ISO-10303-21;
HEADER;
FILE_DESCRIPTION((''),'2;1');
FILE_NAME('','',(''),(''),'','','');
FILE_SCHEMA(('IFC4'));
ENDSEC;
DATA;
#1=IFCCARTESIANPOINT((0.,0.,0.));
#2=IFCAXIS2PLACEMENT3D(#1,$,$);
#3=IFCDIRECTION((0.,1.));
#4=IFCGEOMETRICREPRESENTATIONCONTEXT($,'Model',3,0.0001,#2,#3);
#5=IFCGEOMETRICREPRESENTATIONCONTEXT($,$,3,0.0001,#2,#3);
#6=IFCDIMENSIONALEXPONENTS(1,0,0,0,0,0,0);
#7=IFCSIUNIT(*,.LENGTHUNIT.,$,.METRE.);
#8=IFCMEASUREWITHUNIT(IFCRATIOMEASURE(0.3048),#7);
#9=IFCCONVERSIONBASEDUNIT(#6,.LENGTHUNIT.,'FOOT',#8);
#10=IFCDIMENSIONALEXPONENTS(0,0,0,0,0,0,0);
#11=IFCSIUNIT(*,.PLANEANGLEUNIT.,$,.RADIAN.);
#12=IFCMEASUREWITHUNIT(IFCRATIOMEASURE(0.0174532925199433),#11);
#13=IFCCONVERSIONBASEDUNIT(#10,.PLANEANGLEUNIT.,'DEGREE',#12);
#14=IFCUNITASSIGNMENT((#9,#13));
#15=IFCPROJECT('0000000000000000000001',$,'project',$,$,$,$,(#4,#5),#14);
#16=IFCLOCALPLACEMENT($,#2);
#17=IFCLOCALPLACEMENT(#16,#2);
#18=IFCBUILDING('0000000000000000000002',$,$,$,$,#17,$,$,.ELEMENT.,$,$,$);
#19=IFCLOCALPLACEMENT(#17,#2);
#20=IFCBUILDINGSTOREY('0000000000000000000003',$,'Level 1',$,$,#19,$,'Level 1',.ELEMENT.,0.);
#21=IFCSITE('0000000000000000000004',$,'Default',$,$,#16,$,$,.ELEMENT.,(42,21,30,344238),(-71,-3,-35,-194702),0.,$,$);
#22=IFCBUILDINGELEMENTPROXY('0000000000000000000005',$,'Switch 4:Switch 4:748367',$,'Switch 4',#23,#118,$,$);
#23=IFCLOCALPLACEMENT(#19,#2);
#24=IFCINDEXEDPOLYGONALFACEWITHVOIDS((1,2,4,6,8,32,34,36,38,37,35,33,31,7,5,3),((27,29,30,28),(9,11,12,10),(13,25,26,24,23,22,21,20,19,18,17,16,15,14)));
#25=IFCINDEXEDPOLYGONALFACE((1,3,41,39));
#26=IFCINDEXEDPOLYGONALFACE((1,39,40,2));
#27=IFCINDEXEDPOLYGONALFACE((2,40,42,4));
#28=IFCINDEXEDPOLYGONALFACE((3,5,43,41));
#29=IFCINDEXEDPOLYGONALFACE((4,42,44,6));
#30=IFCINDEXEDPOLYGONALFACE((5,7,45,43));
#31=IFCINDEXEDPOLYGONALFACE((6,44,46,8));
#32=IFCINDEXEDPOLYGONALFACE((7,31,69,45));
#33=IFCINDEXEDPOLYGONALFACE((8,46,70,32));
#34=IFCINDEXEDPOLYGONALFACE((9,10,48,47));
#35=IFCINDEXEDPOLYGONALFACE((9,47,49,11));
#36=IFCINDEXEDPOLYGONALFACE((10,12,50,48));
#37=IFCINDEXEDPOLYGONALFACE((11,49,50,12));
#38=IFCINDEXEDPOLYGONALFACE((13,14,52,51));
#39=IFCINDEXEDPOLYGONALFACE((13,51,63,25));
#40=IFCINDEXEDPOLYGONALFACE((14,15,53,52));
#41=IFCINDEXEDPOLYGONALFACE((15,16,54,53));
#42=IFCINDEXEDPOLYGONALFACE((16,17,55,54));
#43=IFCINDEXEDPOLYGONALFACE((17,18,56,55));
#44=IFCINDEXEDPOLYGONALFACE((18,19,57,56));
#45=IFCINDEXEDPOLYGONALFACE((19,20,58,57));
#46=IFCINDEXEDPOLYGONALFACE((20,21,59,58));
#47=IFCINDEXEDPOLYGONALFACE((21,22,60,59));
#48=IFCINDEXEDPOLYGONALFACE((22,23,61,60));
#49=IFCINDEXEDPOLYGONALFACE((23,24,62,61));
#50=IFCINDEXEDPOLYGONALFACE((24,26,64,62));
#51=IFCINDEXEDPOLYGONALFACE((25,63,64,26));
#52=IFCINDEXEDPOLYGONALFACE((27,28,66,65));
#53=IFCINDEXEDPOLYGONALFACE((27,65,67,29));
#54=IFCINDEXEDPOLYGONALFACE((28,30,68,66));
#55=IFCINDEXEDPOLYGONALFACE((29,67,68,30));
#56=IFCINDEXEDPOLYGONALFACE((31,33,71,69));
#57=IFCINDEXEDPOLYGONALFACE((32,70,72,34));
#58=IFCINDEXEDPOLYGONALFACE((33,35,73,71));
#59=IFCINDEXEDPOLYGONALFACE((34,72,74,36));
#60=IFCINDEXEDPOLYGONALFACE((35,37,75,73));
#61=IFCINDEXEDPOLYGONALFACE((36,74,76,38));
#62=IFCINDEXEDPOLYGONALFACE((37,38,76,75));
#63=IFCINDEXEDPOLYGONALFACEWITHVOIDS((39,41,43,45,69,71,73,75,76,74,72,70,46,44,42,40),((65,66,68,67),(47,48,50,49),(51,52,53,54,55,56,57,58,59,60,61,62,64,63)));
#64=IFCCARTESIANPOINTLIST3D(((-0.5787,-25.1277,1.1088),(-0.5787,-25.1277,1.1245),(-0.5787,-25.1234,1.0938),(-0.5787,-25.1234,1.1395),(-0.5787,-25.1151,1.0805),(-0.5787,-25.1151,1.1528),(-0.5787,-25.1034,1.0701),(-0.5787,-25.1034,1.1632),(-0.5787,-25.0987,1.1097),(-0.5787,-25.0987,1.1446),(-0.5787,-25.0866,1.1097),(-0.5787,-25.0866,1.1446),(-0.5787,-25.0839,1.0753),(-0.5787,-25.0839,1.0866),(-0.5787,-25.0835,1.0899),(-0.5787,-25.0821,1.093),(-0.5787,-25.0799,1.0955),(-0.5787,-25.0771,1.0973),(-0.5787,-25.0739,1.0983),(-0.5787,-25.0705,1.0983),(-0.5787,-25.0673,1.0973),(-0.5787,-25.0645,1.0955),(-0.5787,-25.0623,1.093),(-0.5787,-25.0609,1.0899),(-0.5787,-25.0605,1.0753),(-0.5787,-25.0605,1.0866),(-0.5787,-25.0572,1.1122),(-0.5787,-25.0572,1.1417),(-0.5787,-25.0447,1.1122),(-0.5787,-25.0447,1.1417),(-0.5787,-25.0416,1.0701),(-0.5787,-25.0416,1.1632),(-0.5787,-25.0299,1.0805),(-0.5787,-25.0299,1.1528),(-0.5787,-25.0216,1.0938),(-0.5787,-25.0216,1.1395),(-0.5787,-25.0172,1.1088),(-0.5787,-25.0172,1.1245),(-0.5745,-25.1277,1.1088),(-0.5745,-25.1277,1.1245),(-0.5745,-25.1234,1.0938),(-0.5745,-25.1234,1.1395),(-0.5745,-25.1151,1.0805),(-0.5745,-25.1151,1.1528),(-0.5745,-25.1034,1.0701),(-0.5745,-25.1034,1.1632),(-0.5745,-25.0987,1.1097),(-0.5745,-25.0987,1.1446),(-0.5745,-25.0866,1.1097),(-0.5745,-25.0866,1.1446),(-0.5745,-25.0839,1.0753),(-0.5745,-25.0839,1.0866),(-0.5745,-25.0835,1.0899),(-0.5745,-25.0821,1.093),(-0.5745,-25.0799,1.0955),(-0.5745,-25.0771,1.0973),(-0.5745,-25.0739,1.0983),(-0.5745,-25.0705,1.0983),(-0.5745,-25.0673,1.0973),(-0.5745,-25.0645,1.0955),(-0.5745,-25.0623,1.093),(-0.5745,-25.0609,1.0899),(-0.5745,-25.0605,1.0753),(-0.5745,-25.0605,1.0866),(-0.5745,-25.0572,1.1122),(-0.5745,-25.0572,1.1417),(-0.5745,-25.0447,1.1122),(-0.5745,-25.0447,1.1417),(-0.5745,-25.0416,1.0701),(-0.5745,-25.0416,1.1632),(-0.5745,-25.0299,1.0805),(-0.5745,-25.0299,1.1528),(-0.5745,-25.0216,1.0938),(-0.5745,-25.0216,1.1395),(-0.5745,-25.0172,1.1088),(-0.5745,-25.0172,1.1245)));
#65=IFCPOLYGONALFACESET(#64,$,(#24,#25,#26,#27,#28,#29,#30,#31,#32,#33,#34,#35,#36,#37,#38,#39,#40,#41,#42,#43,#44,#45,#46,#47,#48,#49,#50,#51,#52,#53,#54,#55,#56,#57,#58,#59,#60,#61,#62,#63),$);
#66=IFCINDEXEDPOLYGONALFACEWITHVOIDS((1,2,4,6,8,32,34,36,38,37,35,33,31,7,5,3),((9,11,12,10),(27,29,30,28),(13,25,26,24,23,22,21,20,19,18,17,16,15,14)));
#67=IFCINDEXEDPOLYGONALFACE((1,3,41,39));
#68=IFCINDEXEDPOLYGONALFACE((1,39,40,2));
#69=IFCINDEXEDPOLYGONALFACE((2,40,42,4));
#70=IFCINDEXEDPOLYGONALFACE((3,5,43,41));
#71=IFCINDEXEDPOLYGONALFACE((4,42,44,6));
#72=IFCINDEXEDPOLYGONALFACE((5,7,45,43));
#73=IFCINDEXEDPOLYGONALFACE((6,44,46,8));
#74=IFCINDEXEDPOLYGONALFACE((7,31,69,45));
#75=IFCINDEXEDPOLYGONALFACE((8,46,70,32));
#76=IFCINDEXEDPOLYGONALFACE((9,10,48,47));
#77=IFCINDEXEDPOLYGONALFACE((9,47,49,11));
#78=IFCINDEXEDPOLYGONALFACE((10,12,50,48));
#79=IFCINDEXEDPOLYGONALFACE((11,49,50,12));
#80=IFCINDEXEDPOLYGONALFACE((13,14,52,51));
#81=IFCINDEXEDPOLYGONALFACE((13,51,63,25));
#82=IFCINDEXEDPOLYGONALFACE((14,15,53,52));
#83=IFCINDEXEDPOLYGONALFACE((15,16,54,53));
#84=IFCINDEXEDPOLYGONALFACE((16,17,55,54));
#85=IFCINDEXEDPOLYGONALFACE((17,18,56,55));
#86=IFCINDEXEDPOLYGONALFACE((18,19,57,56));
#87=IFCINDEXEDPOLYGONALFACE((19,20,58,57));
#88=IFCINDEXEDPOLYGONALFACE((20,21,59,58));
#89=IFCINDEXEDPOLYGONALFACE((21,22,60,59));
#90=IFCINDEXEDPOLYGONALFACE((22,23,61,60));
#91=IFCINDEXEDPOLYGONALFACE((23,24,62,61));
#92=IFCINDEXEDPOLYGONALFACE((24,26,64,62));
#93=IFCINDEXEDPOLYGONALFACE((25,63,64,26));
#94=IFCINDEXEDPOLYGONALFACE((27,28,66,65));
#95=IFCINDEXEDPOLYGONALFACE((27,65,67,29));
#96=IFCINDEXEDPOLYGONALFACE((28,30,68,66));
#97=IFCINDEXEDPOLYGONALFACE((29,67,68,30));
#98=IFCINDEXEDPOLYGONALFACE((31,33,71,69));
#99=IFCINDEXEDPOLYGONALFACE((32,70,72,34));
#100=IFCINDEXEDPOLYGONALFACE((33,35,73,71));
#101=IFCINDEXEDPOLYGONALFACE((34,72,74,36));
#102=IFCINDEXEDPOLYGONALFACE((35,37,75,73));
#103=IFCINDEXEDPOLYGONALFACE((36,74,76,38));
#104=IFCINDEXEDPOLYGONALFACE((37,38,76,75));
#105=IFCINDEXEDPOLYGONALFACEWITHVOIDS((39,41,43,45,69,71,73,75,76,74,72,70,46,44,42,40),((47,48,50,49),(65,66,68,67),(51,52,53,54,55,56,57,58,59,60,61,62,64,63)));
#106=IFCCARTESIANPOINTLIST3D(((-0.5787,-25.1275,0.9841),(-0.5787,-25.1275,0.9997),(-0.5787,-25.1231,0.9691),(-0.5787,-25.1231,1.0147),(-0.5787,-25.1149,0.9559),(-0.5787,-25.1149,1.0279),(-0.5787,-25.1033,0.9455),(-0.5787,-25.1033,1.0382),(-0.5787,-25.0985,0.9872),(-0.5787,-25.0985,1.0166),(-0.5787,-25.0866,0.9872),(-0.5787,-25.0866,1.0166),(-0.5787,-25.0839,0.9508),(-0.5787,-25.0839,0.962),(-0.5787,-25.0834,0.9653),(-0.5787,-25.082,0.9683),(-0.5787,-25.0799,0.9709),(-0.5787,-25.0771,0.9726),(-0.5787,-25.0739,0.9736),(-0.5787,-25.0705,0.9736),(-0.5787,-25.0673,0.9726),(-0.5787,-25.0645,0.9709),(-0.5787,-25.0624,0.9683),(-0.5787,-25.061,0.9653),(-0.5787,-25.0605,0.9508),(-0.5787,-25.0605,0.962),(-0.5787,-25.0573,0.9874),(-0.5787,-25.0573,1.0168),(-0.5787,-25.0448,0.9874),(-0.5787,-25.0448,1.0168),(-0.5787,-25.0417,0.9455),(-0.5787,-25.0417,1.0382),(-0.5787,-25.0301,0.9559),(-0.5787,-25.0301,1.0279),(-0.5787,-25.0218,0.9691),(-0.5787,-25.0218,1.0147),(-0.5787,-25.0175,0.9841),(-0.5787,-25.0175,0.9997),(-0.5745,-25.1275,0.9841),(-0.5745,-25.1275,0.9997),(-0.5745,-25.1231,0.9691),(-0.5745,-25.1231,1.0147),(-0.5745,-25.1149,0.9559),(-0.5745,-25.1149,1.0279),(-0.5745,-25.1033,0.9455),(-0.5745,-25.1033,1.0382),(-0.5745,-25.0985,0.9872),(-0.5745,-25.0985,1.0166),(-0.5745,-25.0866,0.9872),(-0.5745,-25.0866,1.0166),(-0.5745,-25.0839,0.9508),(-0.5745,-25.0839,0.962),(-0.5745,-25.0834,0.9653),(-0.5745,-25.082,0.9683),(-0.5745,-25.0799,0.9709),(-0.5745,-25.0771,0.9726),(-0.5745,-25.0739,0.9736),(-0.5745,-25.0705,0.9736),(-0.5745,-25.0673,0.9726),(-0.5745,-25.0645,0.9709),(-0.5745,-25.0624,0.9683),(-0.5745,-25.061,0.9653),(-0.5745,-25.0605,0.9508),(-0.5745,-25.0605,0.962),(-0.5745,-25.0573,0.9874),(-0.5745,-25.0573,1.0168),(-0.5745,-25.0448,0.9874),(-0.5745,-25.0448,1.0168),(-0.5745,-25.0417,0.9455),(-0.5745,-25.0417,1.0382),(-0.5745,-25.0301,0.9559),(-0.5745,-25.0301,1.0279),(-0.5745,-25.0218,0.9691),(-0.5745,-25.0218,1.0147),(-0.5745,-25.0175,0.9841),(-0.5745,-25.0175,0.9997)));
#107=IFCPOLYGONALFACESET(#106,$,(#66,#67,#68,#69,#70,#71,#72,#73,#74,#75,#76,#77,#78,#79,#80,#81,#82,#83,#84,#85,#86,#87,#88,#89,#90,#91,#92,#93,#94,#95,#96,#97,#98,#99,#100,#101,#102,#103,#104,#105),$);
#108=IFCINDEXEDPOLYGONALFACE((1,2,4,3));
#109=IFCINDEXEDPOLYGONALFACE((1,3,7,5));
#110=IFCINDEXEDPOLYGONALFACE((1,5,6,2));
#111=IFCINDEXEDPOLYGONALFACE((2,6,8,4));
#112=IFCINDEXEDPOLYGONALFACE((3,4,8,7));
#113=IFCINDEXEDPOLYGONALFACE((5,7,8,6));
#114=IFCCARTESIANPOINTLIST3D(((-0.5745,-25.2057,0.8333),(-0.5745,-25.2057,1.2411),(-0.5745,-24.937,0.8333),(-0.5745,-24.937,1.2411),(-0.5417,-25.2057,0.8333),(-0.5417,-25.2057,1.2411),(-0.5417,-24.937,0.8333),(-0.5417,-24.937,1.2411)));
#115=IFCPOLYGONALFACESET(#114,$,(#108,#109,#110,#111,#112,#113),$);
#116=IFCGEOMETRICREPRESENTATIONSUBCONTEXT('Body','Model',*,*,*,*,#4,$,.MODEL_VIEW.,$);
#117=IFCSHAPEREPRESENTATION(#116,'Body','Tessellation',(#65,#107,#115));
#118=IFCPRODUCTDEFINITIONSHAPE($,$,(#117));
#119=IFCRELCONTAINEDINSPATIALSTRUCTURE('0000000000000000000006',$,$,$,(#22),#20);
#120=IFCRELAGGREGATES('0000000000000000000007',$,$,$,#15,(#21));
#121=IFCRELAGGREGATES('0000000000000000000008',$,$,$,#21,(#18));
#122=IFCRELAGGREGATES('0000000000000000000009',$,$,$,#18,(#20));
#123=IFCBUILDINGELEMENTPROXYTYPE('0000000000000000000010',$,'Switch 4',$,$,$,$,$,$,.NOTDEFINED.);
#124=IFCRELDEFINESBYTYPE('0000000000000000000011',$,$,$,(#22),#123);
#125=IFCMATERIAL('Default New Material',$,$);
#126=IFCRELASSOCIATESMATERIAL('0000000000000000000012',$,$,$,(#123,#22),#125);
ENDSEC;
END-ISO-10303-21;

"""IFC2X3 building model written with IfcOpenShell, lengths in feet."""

from ifc_helpers import new_model, entity, si_unit, converted_unit, direction, frame, frame_2d, origin, origin_2d_with_axis, place, context, subcontext, project, spatial, polyline, circle_curve, parameter, trimmed, segment, composite_curve, rectangle, outline, extrude, source, transform, mapped, material, type_object, type_shapes, element, save


model = new_model("IFC2X3")

# Units and contexts
model_context = context("Model", 3, precision=0.0001, world=origin(), true_north=direction((0.0, 1.0)))
context_of_model = context(None, 3, precision=0.0001, world=origin(), true_north=direction((0.0, 1.0)))
body_context = subcontext(model_context, "Body", "Model", "MODEL_VIEW")
ifc_project = project(units=[converted_unit("LENGTHUNIT", "FOOT", entity("IfcRatioMeasure", 0.3048), si_unit("LENGTHUNIT", "METRE"), dimensions=[1, 0, 0, 0, 0, 0, 0]), converted_unit("PLANEANGLEUNIT", "DEGREE", entity("IfcRatioMeasure", 0.0174532925199433), si_unit("PLANEANGLEUNIT", "RADIAN"), dimensions=[0, 0, 0, 0, 0, 0, 0])], contexts=[model_context, context_of_model])

# Site, building, storey
site_placement = place(None, origin())
site = spatial("IfcSite", under=ifc_project, at=site_placement, Name="Default", CompositionType="ELEMENT", RefLatitude=(42, 21, 30, 344238), RefLongitude=(-71, -3, -35, -194702), RefElevation=0.0)
building_placement = place(site_placement, origin())
building = spatial("IfcBuilding", under=site, at=building_placement, CompositionType="ELEMENT")
storey_placement = place(building_placement, origin())
storey = spatial("IfcBuildingStorey", under=building, at=storey_placement, Name="Level 1", LongName="Level 1", CompositionType="ELEMENT", Elevation=0.0)

# Shared definitions
ifc_material_1 = material(Name="Default New Material")

# Building element proxy
building_element_proxy_type_1 = type_object("IfcBuildingElementProxyType", Name="Switch 4", PredefinedType="NOTDEFINED", material=ifc_material_1)
shared_shape_1 = source(origin(), body_context, "Body", "SweptSolid", [
    extrude(outline(composite_curve([segment(polyline([(-0.0309, -0.0466), (0.0309, -0.0466)]), True, "CONTINUOUS"), segment(trimmed(circle_curve(frame_2d((-0.0003, 0.0), x_axis=(-1.0, 0.0)), 0.0561), [parameter(123.794741)], [parameter(236.205259)], True, "PARAMETER"), True, "CONTINUOUS"), segment(polyline([(0.0309, 0.0466), (-0.0309, 0.0466)]), True, "CONTINUOUS"), segment(trimmed(circle_curve(frame_2d((0.0003, 0.0), x_axis=(1.0, 0.0)), 0.0561), [parameter(123.794741)], [parameter(236.205259)], True, "PARAMETER"), True, "CONTINUOUS")], self_intersect=False), holes=[polyline([(0.0142, 0.0279), (0.0262, 0.0279), (0.0262, -0.0069), (0.0142, -0.0069), (0.0142, 0.0279)]), polyline([(-0.0153, 0.025), (-0.0153, -0.0045), (-0.0278, -0.0045), (-0.0278, 0.025), (-0.0153, 0.025)]), composite_curve([segment(polyline([(-0.012, -0.0413), (-0.012, -0.03)]), True, "CONTINUOUS"), segment(trimmed(circle_curve(frame_2d((-0.0003, -0.03), x_axis=(-1.0, 0.0)), 0.0117), [parameter(180.0)], [parameter(0.0)], True, "PARAMETER"), False, "CONTINUOUS"), segment(polyline([(0.0115, -0.03), (0.0115, -0.0413)]), True, "CONTINUOUS"), segment(polyline([(0.0115, -0.0413), (-0.012, -0.0413)]), True, "CONTINUOUS")], self_intersect=False)]), frame((-0.0011, 0.0328, 0.2833), z_axis=(0.0, 1.0, 0.0), x_axis=(-1.0, 0.0, 0.0)), (0.0, 0.0, 1.0), 0.0042),
    extrude(outline(composite_curve([segment(polyline([(-0.0308, -0.0464), (0.0308, -0.0464)]), True, "CONTINUOUS"), segment(trimmed(circle_curve(frame_2d((-0.0003, 0.0), x_axis=(-1.0, 0.0)), 0.0558), [parameter(123.794741)], [parameter(236.205259)], True, "PARAMETER"), True, "CONTINUOUS"), segment(polyline([(0.0308, 0.0464), (-0.0308, 0.0464)]), True, "CONTINUOUS"), segment(trimmed(circle_curve(frame_2d((0.0003, 0.0), x_axis=(1.0, 0.0)), 0.0558), [parameter(123.794741)], [parameter(236.205259)], True, "PARAMETER"), True, "CONTINUOUS")], self_intersect=False), holes=[polyline([(0.0141, 0.0247), (0.026, 0.0247), (0.026, -0.0047), (0.0141, -0.0047), (0.0141, 0.0247)]), polyline([(-0.0152, 0.0249), (-0.0152, -0.0045), (-0.0277, -0.0045), (-0.0277, 0.0249), (-0.0152, 0.0249)]), composite_curve([segment(polyline([(-0.012, -0.0411), (-0.012, -0.0299)]), True, "CONTINUOUS"), segment(trimmed(circle_curve(frame_2d((-0.0003, -0.0299), x_axis=(-1.0, 0.0)), 0.0117), [parameter(180.0)], [parameter(0.0)], True, "PARAMETER"), False, "CONTINUOUS"), segment(polyline([(0.0114, -0.0299), (0.0114, -0.0411)]), True, "CONTINUOUS"), segment(polyline([(0.0114, -0.0411), (-0.012, -0.0411)]), True, "CONTINUOUS")], self_intersect=False)]), frame((-0.0011, 0.0328, 0.1586), z_axis=(0.0, 1.0, 0.0), x_axis=(-1.0, 0.0, 0.0)), (0.0, 0.0, 1.0), 0.0042),
    extrude(rectangle(XDim=0.0328, YDim=0.2687, at=origin_2d_with_axis()), frame((0.0, 0.0164, 0.0), z_axis=(0.0, 0.0, 1.0), x_axis=(0.0, -1.0, 0.0)), (0.0, 0.0, 1.0), 0.4078),
])
type_shapes(building_element_proxy_type_1, [shared_shape_1])
for number, where, z_axis, x_axis, name in (
    (1, (-0.5417, -25.0714, 0.8333), (0.0, 0.0, 1.0), (0.0, 1.0, 0.0), "Switch 4:Switch 4:748367"),
):
    element("IfcBuildingElementProxy", number, at=place(storey_placement, frame(where, z_axis=z_axis, x_axis=x_axis)), inside=storey, type_object=building_element_proxy_type_1, material=ifc_material_1, Name=name, ObjectType="Switch 4", context=body_context, shape_type="MappedRepresentation", body=[
        mapped(shared_shape_1, transform((0.0, 0.0, 0.0), scale=1.0)),
    ])

save(model, "model.ifc")
